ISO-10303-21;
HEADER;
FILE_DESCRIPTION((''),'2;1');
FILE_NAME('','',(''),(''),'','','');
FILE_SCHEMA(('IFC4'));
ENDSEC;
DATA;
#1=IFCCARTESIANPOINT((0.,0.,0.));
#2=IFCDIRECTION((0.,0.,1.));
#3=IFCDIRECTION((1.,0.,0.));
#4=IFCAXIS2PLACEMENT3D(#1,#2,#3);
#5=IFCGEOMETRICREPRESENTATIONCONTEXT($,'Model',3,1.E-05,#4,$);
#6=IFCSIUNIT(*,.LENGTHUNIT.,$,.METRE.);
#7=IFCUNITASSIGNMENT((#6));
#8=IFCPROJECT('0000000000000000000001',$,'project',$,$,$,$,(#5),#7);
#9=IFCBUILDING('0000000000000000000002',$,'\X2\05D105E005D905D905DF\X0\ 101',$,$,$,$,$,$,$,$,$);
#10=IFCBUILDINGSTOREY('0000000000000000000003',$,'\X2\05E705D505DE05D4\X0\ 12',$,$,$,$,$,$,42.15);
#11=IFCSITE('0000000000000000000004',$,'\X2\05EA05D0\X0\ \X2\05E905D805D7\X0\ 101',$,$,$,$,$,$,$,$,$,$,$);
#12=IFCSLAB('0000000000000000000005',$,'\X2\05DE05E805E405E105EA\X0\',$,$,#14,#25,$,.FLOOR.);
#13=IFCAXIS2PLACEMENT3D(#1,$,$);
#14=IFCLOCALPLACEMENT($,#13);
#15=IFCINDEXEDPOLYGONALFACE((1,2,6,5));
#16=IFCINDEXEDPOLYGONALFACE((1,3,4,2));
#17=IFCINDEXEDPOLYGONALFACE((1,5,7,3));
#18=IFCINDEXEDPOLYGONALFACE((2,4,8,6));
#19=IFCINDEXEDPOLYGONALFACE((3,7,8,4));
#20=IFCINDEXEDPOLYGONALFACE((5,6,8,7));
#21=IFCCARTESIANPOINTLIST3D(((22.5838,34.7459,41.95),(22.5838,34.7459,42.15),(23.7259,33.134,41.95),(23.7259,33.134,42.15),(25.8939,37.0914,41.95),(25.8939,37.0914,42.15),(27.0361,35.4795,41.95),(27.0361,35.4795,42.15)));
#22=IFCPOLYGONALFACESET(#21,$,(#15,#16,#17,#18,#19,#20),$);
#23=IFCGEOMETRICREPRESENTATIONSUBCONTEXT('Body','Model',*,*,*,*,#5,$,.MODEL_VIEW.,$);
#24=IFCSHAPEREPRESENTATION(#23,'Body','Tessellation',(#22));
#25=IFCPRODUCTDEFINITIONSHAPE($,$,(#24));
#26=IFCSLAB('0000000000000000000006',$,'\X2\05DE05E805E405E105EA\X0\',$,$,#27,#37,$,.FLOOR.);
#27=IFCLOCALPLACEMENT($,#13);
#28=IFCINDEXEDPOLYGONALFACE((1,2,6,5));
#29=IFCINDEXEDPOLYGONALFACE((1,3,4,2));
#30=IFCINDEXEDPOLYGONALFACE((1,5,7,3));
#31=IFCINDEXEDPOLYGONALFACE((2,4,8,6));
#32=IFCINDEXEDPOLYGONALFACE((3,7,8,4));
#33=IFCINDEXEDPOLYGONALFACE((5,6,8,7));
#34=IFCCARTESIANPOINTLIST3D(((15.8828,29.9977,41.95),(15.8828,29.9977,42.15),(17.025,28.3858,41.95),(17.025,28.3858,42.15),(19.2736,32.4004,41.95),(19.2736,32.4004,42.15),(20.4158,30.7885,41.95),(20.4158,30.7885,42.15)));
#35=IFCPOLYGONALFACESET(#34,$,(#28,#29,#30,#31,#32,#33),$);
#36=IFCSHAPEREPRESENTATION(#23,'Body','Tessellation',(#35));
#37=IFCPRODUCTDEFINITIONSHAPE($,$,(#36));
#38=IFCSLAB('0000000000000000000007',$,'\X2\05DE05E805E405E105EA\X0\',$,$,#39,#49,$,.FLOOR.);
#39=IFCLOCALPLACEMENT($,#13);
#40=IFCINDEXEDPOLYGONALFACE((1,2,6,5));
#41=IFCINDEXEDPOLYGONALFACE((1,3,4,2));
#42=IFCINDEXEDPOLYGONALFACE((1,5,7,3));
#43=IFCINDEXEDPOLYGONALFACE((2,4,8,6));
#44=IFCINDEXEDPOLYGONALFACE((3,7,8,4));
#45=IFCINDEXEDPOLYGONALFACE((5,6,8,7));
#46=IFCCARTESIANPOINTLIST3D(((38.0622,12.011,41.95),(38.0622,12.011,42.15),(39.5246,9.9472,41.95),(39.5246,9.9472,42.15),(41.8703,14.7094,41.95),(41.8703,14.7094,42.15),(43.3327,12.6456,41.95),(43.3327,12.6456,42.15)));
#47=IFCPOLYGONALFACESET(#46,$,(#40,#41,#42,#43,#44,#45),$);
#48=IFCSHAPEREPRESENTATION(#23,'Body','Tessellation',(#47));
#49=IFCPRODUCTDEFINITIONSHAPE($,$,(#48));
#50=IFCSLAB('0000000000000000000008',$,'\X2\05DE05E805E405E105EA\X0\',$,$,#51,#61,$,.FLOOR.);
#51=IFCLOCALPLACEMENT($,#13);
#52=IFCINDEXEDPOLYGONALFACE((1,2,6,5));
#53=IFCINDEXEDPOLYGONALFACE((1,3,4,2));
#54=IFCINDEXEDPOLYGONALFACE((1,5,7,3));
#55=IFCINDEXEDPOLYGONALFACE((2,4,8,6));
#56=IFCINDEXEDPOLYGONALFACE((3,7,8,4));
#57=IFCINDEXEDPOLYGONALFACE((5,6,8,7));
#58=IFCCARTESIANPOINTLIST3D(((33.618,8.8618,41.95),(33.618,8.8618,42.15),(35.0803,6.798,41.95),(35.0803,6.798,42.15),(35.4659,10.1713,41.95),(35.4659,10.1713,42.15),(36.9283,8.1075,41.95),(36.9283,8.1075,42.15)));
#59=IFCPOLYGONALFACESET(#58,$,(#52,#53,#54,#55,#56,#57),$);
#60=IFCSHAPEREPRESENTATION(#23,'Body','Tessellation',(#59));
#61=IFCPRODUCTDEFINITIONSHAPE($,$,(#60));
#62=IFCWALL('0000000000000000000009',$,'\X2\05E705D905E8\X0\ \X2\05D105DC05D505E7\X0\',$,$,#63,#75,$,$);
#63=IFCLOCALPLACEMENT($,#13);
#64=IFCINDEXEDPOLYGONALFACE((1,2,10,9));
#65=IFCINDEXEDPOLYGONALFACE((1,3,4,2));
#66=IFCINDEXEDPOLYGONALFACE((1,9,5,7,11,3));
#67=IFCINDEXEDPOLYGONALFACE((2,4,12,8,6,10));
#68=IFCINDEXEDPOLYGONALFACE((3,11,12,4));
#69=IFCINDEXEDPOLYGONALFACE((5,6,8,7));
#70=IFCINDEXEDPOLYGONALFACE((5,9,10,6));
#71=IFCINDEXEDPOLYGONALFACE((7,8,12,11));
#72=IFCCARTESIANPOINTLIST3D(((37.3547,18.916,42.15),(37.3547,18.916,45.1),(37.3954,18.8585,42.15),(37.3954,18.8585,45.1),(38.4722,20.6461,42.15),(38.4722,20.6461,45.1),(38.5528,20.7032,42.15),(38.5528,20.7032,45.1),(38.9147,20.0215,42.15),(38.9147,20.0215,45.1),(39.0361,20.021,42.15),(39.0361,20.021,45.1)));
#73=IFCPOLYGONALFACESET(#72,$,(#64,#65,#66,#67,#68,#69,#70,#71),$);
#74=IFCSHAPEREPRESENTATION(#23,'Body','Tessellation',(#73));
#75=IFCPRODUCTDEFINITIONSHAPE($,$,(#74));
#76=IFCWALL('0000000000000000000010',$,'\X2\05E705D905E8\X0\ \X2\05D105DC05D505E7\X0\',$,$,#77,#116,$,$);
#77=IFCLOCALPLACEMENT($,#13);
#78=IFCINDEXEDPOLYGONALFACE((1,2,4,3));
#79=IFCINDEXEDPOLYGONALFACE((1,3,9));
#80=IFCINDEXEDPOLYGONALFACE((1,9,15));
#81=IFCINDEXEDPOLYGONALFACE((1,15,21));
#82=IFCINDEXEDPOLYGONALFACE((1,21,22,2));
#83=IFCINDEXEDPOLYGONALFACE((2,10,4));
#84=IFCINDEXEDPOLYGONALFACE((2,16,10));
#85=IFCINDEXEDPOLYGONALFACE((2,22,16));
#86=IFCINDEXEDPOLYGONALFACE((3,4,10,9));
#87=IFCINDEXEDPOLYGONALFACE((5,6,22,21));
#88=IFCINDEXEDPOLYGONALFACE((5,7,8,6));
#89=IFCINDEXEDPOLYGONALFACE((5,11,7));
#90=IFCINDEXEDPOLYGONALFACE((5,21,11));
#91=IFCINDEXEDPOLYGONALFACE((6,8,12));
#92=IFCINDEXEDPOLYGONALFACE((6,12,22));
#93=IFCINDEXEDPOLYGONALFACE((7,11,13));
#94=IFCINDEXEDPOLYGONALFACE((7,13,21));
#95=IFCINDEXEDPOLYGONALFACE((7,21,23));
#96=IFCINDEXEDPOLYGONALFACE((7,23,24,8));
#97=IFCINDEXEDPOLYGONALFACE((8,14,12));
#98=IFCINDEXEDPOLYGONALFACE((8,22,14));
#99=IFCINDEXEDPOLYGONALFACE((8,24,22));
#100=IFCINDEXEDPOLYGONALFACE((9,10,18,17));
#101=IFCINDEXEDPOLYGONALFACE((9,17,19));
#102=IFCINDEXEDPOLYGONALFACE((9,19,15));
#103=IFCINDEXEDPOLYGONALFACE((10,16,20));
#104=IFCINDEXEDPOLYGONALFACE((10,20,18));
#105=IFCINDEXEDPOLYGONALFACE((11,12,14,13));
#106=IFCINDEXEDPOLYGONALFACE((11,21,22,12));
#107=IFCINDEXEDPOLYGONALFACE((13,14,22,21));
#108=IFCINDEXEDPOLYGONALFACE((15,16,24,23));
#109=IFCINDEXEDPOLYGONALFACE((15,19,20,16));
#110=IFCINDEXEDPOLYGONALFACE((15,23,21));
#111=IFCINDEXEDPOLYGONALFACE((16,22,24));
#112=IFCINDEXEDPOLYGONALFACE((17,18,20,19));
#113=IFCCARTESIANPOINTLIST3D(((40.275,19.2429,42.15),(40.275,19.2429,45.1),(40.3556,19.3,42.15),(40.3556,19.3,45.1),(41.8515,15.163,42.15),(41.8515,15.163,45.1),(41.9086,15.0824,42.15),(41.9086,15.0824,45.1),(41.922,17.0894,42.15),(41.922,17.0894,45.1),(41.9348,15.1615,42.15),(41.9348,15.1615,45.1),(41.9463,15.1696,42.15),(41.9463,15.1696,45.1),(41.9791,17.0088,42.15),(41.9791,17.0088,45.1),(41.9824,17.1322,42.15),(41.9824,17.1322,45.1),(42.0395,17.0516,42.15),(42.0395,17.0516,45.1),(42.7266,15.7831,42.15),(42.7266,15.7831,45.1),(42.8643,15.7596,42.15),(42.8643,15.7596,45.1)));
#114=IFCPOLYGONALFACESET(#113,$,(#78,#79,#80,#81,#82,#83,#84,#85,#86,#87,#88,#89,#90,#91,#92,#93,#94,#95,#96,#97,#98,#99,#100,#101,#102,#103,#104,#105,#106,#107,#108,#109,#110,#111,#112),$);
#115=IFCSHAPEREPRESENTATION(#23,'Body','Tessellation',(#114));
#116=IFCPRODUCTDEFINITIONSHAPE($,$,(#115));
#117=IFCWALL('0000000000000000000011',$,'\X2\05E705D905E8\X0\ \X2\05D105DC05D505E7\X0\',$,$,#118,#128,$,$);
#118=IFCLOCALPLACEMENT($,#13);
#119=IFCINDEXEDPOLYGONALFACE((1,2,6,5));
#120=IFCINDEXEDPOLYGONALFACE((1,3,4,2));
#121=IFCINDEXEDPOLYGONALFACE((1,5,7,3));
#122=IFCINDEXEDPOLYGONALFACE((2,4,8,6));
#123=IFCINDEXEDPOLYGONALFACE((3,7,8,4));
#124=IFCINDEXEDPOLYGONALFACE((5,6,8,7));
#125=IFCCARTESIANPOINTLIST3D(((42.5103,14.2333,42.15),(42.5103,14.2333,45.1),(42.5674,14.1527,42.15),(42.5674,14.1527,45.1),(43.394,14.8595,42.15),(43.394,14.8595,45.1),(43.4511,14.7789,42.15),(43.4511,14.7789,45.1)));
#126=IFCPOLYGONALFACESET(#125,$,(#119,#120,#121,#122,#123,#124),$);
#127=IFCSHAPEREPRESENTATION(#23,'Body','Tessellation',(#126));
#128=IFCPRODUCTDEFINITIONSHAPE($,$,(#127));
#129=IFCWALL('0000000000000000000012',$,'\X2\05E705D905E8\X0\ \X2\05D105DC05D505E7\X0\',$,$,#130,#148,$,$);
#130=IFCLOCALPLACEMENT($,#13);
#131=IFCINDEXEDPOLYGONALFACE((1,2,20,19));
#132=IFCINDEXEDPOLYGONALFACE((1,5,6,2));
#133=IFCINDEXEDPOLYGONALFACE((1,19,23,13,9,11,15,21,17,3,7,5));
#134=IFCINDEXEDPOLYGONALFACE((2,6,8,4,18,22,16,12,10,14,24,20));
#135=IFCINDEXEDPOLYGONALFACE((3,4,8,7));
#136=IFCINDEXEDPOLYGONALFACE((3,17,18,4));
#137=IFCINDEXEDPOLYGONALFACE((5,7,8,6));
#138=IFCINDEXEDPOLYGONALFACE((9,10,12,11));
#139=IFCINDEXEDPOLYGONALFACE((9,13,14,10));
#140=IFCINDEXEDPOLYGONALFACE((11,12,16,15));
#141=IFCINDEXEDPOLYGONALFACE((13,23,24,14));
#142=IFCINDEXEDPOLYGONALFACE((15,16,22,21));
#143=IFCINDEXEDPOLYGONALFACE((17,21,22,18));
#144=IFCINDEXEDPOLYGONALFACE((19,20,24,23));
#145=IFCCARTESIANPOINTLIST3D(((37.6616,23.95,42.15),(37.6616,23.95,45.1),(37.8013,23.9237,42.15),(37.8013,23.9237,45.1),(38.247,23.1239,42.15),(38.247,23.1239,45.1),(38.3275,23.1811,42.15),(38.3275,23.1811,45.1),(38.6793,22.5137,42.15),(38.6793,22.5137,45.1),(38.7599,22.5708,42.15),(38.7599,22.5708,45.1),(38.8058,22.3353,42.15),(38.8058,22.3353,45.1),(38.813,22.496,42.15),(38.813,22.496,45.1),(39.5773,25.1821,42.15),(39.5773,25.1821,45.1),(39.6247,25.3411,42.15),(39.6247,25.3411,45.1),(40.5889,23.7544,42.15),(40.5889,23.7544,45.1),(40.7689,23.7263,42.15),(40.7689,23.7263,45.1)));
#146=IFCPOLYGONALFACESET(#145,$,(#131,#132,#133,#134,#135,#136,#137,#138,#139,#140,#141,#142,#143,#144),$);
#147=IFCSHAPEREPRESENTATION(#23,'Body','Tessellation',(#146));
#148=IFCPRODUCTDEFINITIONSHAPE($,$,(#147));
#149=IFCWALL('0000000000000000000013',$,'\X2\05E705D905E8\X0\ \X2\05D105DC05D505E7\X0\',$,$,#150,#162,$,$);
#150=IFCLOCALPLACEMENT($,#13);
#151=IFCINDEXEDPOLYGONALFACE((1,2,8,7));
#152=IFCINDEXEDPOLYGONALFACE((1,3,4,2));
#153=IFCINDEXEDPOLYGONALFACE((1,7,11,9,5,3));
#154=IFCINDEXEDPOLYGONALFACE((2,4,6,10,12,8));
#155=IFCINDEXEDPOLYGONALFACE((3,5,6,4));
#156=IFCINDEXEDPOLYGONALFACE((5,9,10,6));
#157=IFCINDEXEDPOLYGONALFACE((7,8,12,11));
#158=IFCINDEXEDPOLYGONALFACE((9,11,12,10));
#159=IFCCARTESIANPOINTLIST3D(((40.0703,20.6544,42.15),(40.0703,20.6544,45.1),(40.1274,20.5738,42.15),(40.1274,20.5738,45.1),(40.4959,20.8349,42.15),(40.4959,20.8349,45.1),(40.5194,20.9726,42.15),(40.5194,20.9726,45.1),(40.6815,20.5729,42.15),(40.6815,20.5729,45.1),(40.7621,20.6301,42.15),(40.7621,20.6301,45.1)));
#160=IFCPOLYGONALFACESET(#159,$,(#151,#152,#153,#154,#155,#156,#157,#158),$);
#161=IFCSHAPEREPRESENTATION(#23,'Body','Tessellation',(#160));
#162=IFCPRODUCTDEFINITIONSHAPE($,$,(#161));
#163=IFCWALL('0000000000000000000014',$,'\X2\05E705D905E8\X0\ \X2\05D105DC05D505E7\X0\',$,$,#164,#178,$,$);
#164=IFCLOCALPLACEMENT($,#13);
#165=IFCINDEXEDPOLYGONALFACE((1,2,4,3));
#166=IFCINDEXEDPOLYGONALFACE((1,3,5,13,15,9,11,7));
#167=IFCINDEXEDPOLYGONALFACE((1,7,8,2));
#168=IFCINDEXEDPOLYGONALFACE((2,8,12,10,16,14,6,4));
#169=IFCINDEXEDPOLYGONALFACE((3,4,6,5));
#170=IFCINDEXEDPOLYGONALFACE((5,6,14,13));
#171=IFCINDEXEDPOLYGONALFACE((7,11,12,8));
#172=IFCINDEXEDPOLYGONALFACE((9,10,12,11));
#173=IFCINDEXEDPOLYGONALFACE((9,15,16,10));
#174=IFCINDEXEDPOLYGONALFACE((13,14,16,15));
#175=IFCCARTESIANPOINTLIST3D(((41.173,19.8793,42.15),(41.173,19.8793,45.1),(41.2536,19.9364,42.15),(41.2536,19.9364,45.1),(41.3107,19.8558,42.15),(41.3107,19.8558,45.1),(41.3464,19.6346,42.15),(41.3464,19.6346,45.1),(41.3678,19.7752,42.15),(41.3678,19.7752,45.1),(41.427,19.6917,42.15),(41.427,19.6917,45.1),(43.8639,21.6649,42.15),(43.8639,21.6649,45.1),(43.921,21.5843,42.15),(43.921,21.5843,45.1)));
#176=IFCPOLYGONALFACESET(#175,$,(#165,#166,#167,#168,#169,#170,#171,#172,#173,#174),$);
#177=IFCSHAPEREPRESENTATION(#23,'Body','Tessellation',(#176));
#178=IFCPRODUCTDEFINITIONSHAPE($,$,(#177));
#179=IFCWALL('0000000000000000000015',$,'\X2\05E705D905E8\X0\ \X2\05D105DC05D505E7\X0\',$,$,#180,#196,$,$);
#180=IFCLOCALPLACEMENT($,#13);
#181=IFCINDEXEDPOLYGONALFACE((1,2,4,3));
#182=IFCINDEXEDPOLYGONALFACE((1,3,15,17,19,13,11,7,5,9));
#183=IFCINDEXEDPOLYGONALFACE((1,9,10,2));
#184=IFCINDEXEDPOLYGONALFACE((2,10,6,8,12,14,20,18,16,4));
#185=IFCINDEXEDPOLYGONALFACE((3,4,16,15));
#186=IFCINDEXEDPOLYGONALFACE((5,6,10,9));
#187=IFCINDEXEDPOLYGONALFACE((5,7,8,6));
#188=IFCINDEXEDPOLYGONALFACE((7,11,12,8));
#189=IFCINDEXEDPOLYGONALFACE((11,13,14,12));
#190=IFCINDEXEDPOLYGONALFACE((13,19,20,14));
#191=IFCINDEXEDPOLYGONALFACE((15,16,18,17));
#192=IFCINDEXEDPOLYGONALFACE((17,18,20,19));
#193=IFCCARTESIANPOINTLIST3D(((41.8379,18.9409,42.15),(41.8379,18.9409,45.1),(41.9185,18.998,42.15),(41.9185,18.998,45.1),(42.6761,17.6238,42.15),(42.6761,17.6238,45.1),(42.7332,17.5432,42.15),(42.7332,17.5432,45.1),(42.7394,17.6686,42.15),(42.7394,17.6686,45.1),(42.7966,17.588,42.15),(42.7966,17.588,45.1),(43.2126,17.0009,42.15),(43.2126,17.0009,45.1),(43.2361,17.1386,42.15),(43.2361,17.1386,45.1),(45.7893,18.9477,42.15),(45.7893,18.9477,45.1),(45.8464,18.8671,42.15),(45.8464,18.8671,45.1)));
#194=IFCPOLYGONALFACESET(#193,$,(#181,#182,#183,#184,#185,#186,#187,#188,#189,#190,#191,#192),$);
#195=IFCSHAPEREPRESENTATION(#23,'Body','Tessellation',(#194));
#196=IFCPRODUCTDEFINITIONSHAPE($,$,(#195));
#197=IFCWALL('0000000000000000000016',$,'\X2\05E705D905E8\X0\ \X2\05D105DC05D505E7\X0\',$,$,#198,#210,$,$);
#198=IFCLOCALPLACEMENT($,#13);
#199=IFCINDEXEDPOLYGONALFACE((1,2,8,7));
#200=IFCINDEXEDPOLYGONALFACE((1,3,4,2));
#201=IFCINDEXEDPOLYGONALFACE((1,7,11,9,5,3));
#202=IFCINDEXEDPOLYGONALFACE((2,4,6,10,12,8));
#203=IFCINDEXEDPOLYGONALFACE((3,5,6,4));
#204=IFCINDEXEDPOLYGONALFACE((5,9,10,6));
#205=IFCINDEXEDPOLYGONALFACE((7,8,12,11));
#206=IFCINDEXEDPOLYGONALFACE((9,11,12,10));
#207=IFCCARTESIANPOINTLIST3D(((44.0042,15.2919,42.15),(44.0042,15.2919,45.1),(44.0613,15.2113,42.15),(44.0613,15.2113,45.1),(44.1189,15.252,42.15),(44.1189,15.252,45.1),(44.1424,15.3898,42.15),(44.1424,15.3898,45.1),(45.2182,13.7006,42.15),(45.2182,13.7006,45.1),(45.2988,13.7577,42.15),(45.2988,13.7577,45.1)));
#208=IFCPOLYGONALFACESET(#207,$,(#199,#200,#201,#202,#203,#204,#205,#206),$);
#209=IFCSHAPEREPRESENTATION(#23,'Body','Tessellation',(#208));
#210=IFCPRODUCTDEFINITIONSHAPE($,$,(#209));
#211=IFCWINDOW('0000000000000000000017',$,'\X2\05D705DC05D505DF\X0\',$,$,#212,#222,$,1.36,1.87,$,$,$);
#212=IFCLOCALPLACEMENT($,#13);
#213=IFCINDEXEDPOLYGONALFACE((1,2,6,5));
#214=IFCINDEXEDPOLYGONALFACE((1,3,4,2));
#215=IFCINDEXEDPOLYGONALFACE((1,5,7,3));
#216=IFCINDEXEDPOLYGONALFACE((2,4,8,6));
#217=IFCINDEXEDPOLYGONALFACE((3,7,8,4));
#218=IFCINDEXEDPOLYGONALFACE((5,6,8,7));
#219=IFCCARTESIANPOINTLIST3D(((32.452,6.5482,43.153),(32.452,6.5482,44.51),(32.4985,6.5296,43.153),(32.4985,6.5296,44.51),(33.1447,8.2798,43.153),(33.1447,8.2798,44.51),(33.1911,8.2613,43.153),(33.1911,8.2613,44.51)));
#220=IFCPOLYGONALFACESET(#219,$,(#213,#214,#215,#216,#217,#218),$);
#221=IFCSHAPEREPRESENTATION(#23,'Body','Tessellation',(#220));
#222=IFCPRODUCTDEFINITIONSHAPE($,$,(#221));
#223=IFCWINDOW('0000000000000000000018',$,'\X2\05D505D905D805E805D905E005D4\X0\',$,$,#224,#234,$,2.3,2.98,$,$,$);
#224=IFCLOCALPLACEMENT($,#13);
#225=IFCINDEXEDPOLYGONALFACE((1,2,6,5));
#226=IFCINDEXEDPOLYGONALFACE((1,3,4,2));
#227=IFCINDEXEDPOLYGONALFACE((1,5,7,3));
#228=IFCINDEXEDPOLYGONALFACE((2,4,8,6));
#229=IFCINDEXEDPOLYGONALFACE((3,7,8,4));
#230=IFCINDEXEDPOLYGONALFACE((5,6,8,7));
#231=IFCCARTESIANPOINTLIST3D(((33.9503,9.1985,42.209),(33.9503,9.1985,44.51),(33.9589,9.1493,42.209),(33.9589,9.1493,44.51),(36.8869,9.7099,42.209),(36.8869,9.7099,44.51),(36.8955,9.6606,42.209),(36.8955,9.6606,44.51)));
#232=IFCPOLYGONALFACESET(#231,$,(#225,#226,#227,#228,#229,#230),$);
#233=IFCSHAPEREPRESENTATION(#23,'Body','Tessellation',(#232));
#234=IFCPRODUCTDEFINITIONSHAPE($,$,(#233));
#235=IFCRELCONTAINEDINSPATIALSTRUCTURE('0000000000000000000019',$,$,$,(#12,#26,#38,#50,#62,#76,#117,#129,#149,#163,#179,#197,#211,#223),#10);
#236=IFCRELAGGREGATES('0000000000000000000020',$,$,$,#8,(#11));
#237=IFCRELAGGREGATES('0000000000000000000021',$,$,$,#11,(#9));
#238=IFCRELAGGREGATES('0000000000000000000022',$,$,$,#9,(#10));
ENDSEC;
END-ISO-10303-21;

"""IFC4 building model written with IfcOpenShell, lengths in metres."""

from ifc_helpers import new_model, si_unit, frame, origin_with_axes, context, subcontext, project, spatial, polyline, outline, extrude, element, save


model = new_model("IFC4")

# Units and contexts
model_context = context("Model", 3, precision=1e-05, world=origin_with_axes())
body_context = subcontext(model_context, "Body", "Model", "MODEL_VIEW")
ifc_project = project(units=[si_unit("LENGTHUNIT", "METRE")], contexts=[model_context])

# Site, building, storey
site = spatial("IfcSite", under=ifc_project, Name="תא שטח 101")
building = spatial("IfcBuilding", under=site, Name="בניין 101")
storey = spatial("IfcBuildingStorey", under=building, Name="קומה 12", Elevation=42.15)

# Slabs
element("IfcSlab", 1, inside=storey, Name="מרפסת", PredefinedType="FLOOR", context=body_context, shape_type="SweptSolid", body=[
    extrude(outline(polyline([(22.5838, 34.7459), (25.8939, 37.0914), (27.0361, 35.4795), (23.7259, 33.134), (22.5838, 34.7459)])), frame((0.0, 0.0, 41.95)), (0.0, 0.0, 1.0), 0.2),
])
element("IfcSlab", 2, inside=storey, Name="מרפסת", PredefinedType="FLOOR", context=body_context, shape_type="SweptSolid", body=[
    extrude(outline(polyline([(15.8828, 29.9977), (19.2736, 32.4004), (20.4158, 30.7885), (17.025, 28.3858), (15.8828, 29.9977)])), frame((0.0, 0.0, 41.95)), (0.0, 0.0, 1.0), 0.2),
])
element("IfcSlab", 3, inside=storey, Name="מרפסת", PredefinedType="FLOOR", context=body_context, shape_type="SweptSolid", body=[
    extrude(outline(polyline([(38.0622, 12.011), (41.8703, 14.7094), (43.3327, 12.6456), (39.5246, 9.9472), (38.0622, 12.011)])), frame((0.0, 0.0, 41.95)), (0.0, 0.0, 1.0), 0.2),
])
element("IfcSlab", 4, inside=storey, Name="מרפסת", PredefinedType="FLOOR", context=body_context, shape_type="SweptSolid", body=[
    extrude(outline(polyline([(33.618, 8.8618), (35.4659, 10.1713), (36.9283, 8.1075), (35.0803, 6.798), (33.618, 8.8618)])), frame((0.0, 0.0, 41.95)), (0.0, 0.0, 1.0), 0.2),
])

# Walls
element("IfcWall", 5, inside=storey, Name="קיר בלוק", context=body_context, shape_type="SweptSolid", body=[
    extrude(outline(polyline([(37.3954, 18.8585), (39.0361, 20.021), (38.5528, 20.7032), (38.4722, 20.6461), (38.9147, 20.0215), (37.3547, 18.916), (37.3954, 18.8585)])), frame((0.0, 0.0, 42.15)), (0.0, 0.0, 1.0), 2.95),
])
element("IfcWall", 6, inside=storey, Name="קיר בלוק", context=body_context, shape_type="SweptSolid", body=[
    extrude(outline(polyline([(41.9086, 15.0824), (42.8643, 15.7596), (41.9791, 17.0088), (42.0395, 17.0516), (41.9824, 17.1322), (41.922, 17.0894), (40.3556, 19.3), (40.275, 19.2429), (42.7266, 15.7831), (41.8515, 15.163), (41.9086, 15.0824)]), holes=[polyline([(41.9463, 15.1696), (41.9348, 15.1615), (42.7266, 15.7831), (41.9463, 15.1696)])]), frame((0.0, 0.0, 42.15)), (0.0, 0.0, 1.0), 2.95),
])
element("IfcWall", 7, inside=storey, Name="קיר בלוק", context=body_context, shape_type="SweptSolid", body=[
    extrude(outline(polyline([(42.5103, 14.2333), (42.5674, 14.1527), (43.4511, 14.7789), (43.394, 14.8595), (42.5103, 14.2333)])), frame((0.0, 0.0, 42.15)), (0.0, 0.0, 1.0), 2.95),
])
element("IfcWall", 8, inside=storey, Name="קיר בלוק", context=body_context, shape_type="SweptSolid", body=[
    extrude(outline(polyline([(38.3275, 23.1811), (37.8013, 23.9237), (39.5773, 25.1821), (40.5889, 23.7544), (38.813, 22.496), (38.7599, 22.5708), (38.6793, 22.5137), (38.8058, 22.3353), (40.7689, 23.7263), (39.6247, 25.3411), (37.6616, 23.95), (38.247, 23.1239), (38.3275, 23.1811)])), frame((0.0, 0.0, 42.15)), (0.0, 0.0, 1.0), 2.95),
])
element("IfcWall", 9, inside=storey, Name="קיר בלוק", context=body_context, shape_type="SweptSolid", body=[
    extrude(outline(polyline([(40.1274, 20.5738), (40.4959, 20.8349), (40.6815, 20.5729), (40.7621, 20.6301), (40.5194, 20.9726), (40.0703, 20.6544), (40.1274, 20.5738)])), frame((0.0, 0.0, 42.15)), (0.0, 0.0, 1.0), 2.95),
])
element("IfcWall", 10, inside=storey, Name="קיר בלוק", context=body_context, shape_type="SweptSolid", body=[
    extrude(outline(polyline([(41.3464, 19.6346), (41.427, 19.6917), (41.3678, 19.7752), (43.921, 21.5843), (43.8639, 21.6649), (41.3107, 19.8558), (41.2536, 19.9364), (41.173, 19.8793), (41.3464, 19.6346)])), frame((0.0, 0.0, 42.15)), (0.0, 0.0, 1.0), 2.95),
])
element("IfcWall", 11, inside=storey, Name="קיר בלוק", context=body_context, shape_type="SweptSolid", body=[
    extrude(outline(polyline([(42.7966, 17.588), (43.2126, 17.0009), (45.8464, 18.8671), (45.7893, 18.9477), (43.2361, 17.1386), (41.9185, 18.998), (41.8379, 18.9409), (42.7394, 17.6686), (42.6761, 17.6238), (42.7332, 17.5432), (42.7966, 17.588)])), frame((0.0, 0.0, 42.15)), (0.0, 0.0, 1.0), 2.95),
])
element("IfcWall", 12, inside=storey, Name="קיר בלוק", context=body_context, shape_type="SweptSolid", body=[
    extrude(outline(polyline([(44.1424, 15.3898), (44.0042, 15.2919), (44.0613, 15.2113), (44.1189, 15.252), (45.2182, 13.7006), (45.2988, 13.7577), (44.1424, 15.3898)])), frame((0.0, 0.0, 42.15)), (0.0, 0.0, 1.0), 2.95),
])

# Windows
element("IfcWindow", 13, inside=storey, Name="חלון", OverallHeight=1.36, OverallWidth=1.87, context=body_context, shape_type="SweptSolid", body=[
    extrude(outline(polyline([(32.4985, 6.5296), (33.1911, 8.2613), (33.1447, 8.2798), (32.452, 6.5482), (32.4985, 6.5296)])), frame((0.0, 0.0, 43.153)), (0.0, 0.0, 1.0), 1.357),
])
element("IfcWindow", 14, inside=storey, Name="ויטרינה", OverallHeight=2.3, OverallWidth=2.98, context=body_context, shape_type="SweptSolid", body=[
    extrude(outline(polyline([(33.9589, 9.1493), (36.8955, 9.6606), (36.8869, 9.7099), (33.9503, 9.1985), (33.9589, 9.1493)])), frame((0.0, 0.0, 42.209)), (0.0, 0.0, 1.0), 2.301),
])

save(model, "model.ifc")
